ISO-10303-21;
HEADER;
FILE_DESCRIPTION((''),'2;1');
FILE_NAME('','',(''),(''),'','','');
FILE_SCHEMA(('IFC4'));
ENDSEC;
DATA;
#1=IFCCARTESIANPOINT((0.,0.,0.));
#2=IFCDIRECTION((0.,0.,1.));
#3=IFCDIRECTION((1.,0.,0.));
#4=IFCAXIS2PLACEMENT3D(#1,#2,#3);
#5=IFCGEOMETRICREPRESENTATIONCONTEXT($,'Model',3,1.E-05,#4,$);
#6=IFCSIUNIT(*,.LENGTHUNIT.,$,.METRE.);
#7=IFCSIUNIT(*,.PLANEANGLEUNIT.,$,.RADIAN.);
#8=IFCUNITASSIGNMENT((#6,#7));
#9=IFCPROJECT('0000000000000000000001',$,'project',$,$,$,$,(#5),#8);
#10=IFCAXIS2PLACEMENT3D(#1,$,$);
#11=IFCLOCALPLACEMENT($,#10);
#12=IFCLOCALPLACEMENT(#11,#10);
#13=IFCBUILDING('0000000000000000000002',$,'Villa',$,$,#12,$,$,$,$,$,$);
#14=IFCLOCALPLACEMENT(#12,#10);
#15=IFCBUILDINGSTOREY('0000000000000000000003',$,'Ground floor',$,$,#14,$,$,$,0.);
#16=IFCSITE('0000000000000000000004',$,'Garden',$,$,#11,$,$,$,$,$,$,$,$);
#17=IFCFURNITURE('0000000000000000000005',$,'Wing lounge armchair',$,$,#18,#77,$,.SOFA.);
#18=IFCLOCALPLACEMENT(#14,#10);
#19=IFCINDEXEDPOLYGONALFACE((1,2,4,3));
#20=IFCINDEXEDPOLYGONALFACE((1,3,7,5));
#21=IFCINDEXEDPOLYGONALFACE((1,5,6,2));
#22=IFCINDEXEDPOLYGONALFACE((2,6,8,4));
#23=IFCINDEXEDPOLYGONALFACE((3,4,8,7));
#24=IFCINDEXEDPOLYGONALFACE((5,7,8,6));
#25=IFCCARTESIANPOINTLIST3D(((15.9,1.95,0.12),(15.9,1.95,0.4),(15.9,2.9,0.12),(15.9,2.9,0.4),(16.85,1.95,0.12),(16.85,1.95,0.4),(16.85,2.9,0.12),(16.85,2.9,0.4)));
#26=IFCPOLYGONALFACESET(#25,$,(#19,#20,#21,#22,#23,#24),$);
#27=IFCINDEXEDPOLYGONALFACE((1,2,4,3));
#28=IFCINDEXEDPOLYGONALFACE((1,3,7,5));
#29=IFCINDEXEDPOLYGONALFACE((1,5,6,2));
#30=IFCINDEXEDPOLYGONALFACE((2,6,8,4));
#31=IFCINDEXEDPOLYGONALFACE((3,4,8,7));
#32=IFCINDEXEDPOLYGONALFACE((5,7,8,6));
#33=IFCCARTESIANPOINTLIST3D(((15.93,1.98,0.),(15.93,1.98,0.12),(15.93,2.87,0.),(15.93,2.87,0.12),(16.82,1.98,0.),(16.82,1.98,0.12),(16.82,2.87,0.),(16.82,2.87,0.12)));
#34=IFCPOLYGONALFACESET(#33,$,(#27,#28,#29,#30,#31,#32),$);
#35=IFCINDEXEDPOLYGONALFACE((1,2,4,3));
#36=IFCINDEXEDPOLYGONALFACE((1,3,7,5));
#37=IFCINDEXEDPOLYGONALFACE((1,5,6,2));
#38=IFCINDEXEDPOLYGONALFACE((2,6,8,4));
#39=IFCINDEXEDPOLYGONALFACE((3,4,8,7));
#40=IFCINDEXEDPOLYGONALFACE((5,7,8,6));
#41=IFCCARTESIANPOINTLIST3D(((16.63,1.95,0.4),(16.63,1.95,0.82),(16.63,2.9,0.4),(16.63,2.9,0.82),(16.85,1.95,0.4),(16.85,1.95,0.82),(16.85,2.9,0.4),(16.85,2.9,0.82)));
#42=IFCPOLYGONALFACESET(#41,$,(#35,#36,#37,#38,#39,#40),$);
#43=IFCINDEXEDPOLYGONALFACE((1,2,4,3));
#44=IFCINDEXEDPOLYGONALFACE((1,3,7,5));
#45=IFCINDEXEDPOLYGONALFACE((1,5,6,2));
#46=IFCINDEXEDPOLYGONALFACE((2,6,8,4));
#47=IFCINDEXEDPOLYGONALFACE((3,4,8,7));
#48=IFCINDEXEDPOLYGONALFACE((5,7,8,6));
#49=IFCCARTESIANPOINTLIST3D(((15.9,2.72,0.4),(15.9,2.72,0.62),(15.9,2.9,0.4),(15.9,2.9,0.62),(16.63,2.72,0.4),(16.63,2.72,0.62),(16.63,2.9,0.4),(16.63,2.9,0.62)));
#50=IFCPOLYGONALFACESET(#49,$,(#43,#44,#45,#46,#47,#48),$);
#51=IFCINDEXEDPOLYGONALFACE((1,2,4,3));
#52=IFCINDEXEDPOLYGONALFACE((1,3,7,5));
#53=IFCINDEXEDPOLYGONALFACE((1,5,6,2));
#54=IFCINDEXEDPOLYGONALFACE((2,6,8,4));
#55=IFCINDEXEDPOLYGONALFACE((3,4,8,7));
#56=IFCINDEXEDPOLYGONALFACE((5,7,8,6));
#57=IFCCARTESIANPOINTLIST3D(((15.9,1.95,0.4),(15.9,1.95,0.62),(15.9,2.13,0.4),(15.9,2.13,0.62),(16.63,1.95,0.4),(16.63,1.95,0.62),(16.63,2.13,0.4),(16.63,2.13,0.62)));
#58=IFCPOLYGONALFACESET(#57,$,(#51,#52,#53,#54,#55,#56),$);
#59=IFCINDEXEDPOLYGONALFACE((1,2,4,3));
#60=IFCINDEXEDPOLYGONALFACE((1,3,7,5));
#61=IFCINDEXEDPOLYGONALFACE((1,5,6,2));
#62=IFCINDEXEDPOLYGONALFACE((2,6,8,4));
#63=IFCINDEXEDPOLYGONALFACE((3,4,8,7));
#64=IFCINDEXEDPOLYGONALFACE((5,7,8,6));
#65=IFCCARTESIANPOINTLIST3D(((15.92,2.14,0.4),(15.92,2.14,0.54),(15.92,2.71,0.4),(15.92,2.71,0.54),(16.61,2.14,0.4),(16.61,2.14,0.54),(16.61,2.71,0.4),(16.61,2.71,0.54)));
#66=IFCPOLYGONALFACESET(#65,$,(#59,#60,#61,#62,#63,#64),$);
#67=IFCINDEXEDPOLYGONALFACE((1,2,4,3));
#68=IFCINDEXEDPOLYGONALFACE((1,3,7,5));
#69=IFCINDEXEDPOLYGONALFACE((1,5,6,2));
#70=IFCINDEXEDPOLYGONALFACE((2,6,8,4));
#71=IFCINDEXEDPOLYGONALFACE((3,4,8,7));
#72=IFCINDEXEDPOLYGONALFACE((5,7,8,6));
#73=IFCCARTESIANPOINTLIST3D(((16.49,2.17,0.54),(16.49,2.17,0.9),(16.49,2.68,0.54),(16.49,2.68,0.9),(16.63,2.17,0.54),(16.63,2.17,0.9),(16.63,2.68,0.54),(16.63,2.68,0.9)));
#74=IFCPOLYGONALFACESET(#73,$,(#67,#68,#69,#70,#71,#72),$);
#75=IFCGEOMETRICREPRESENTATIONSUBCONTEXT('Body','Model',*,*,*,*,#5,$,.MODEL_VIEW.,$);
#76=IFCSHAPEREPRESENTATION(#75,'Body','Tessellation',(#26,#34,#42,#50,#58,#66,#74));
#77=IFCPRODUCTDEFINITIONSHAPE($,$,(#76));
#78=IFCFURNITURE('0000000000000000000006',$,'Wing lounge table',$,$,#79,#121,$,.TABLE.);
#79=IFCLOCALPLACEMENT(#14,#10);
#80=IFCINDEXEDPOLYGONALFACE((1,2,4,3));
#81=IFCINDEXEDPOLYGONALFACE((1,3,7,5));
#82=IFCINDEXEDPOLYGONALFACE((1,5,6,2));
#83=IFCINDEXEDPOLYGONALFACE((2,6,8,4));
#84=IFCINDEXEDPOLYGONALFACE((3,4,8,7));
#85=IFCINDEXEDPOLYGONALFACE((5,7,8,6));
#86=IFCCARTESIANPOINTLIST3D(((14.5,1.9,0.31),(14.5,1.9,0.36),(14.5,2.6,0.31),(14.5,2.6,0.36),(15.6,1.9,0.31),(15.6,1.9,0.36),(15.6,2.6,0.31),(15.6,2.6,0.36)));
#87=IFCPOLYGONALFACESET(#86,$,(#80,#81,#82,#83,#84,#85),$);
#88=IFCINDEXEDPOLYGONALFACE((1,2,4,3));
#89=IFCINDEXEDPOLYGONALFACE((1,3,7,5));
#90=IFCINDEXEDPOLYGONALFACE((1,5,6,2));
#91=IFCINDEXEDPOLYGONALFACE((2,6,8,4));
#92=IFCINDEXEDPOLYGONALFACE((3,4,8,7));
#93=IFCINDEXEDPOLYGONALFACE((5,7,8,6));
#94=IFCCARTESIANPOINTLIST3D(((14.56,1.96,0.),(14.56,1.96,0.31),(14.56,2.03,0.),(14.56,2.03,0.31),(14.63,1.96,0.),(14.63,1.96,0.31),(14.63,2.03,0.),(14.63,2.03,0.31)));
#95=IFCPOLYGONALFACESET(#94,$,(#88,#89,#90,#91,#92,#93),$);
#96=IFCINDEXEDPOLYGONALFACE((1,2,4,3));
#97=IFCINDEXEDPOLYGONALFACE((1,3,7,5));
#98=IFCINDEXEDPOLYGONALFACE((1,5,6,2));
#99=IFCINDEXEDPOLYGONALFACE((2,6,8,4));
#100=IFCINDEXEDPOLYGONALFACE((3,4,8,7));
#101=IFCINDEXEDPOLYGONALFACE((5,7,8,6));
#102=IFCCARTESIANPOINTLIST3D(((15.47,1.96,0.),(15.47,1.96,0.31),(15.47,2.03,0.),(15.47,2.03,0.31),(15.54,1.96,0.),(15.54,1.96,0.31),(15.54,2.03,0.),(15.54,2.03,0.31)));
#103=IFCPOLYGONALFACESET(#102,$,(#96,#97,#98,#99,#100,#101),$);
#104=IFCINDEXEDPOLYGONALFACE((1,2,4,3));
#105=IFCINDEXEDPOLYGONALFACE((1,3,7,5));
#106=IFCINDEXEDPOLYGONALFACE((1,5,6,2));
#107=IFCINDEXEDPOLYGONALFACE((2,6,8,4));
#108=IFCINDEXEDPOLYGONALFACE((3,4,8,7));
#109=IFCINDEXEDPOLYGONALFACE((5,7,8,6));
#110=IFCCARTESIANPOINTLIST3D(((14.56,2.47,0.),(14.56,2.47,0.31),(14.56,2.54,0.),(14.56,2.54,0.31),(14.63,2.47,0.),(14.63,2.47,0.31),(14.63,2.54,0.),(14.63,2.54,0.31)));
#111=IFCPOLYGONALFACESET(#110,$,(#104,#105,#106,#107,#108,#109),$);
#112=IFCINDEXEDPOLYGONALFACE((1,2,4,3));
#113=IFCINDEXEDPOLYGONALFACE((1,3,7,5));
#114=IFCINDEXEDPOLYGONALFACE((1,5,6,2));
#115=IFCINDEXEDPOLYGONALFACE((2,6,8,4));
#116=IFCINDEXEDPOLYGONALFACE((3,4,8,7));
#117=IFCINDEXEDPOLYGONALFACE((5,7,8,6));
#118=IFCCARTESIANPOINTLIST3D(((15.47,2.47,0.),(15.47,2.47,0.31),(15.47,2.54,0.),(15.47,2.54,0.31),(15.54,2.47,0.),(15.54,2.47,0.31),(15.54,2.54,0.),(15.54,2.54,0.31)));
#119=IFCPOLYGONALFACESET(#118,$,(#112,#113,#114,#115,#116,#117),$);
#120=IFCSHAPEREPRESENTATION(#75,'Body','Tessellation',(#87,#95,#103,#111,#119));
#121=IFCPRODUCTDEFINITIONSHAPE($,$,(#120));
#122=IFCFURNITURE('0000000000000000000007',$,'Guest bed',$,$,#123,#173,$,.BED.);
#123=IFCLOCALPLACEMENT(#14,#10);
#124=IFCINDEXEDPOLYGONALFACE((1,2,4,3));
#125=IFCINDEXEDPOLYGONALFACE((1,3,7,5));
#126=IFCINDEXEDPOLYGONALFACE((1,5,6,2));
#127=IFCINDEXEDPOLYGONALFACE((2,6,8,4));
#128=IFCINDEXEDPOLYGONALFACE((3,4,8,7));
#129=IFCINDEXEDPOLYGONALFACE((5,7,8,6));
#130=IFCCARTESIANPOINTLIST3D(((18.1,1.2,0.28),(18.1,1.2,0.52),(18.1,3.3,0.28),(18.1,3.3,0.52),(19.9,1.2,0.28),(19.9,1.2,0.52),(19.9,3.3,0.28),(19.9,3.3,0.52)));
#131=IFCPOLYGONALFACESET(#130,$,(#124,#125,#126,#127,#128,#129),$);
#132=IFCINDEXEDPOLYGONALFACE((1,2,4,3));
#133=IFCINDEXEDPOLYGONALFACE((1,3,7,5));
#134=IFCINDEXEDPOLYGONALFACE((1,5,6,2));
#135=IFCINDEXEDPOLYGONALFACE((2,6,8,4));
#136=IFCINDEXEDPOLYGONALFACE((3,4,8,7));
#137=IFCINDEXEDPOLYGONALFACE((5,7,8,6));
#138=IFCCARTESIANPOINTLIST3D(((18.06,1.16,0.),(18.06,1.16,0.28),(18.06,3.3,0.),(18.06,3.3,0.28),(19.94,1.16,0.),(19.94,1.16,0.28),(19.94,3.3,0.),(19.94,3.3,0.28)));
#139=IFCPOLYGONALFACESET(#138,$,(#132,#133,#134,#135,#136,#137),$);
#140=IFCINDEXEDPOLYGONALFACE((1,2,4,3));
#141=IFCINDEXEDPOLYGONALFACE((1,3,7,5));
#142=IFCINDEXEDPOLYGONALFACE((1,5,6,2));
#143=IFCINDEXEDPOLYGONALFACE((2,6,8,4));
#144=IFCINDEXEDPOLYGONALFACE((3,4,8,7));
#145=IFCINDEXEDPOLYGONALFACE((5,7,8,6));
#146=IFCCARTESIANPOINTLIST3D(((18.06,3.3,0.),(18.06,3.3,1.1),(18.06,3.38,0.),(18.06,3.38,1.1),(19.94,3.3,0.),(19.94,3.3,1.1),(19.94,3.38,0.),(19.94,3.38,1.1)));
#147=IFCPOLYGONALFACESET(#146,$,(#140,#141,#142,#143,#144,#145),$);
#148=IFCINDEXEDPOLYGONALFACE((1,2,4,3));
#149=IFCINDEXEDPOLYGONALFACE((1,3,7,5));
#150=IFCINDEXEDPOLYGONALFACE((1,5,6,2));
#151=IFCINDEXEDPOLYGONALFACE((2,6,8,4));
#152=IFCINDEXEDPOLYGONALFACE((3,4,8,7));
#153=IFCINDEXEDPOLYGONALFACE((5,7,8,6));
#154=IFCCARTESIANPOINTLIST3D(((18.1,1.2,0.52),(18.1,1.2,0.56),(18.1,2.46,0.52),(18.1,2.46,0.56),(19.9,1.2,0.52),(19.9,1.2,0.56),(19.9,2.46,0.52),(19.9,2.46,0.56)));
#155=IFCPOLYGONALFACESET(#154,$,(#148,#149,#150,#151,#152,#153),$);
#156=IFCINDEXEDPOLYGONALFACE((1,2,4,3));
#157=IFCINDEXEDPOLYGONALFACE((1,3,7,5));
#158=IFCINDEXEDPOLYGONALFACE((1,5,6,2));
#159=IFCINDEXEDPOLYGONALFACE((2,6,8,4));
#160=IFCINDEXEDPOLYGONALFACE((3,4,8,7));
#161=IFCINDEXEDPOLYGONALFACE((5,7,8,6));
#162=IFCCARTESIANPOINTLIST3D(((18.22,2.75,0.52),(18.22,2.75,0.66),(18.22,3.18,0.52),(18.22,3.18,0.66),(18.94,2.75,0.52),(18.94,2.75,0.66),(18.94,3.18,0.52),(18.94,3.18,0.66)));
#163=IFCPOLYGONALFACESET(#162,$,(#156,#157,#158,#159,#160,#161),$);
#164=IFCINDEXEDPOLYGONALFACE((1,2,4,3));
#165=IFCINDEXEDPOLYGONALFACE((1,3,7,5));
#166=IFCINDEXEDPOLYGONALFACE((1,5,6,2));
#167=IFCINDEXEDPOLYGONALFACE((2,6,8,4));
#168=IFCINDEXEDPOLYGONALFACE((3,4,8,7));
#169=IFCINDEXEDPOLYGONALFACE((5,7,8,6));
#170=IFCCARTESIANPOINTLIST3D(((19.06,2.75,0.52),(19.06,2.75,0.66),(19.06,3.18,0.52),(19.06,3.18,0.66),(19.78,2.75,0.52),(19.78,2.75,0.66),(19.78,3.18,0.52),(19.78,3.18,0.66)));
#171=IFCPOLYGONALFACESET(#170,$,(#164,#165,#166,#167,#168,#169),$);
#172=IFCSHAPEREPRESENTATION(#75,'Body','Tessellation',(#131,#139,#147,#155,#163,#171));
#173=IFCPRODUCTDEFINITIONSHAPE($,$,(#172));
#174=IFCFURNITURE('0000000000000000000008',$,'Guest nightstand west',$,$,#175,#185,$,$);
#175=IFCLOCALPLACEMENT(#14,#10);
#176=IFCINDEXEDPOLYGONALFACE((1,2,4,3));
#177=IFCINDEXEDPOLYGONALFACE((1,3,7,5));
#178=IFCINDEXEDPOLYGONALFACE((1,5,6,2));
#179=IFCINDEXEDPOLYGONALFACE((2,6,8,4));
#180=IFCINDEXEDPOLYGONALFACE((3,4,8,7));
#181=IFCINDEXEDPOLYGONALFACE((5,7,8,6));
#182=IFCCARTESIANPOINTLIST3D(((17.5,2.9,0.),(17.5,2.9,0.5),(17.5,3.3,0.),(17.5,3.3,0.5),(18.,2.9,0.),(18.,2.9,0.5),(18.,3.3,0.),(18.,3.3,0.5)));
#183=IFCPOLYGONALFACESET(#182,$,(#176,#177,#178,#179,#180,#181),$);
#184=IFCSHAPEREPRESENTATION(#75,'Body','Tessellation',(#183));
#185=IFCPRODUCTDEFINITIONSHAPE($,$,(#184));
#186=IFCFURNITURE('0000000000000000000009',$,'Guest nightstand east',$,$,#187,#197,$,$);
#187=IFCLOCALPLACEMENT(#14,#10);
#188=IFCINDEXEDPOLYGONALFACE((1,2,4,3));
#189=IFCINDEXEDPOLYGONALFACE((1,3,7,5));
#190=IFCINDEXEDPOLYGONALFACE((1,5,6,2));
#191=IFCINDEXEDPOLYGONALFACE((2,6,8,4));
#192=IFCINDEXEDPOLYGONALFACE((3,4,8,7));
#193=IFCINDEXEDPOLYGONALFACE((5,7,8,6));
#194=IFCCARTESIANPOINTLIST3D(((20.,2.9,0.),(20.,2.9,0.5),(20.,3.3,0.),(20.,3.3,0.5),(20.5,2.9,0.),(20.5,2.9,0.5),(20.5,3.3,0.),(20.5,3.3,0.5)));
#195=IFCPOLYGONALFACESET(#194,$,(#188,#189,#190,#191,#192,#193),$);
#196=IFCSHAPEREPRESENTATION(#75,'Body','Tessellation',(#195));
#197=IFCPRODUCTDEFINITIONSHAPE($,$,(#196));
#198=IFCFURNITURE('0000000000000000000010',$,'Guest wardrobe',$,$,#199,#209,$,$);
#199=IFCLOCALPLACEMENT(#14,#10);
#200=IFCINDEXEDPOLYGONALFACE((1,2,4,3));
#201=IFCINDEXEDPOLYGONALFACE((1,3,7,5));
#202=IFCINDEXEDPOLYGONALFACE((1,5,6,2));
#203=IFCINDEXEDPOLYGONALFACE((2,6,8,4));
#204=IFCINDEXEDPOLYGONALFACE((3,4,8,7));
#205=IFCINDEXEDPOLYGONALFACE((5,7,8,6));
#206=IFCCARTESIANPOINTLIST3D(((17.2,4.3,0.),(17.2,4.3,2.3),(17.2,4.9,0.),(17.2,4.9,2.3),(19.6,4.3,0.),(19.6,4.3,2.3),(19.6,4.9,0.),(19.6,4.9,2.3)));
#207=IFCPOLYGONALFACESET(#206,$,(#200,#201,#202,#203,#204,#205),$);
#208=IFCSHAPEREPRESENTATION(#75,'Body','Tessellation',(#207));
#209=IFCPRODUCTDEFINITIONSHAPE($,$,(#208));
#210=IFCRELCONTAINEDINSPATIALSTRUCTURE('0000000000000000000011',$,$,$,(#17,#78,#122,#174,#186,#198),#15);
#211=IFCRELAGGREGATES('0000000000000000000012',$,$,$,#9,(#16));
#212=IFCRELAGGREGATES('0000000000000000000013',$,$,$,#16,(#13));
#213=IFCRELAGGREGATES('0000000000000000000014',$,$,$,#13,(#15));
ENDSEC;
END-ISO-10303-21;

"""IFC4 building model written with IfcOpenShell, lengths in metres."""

from ifc_helpers import new_model, si_unit, frame, frame_2d, origin, origin_with_axes, place, context, subcontext, project, spatial, rectangle, extrude, element, save


model = new_model("IFC4")

# Units and contexts
model_context = context("Model", 3, precision=1e-05, world=origin_with_axes())
body_context = subcontext(model_context, "Body", "Model", "MODEL_VIEW")
ifc_project = project(units=[si_unit("LENGTHUNIT", "METRE"), si_unit("PLANEANGLEUNIT", "RADIAN")], contexts=[model_context])

# Site, building, storey
site_placement = place(None, origin())
site = spatial("IfcSite", under=ifc_project, at=site_placement, Name="Garden")
building_placement = place(site_placement, origin())
building = spatial("IfcBuilding", under=site, at=building_placement, Name="Villa")
storey_placement = place(building_placement, origin())
storey = spatial("IfcBuildingStorey", under=building, at=storey_placement, Name="Ground floor", Elevation=0.0)

# Furniture
furniture_1_placement = place(storey_placement, frame((15.9, 2.9, 0.0), x_axis=(0.0, -1.0, 0.0)))
element("IfcFurniture", 1, at=furniture_1_placement, inside=storey, Name="Wing lounge armchair", PredefinedType="SOFA", context=body_context, shape_type="SweptSolid", body=[
    extrude(rectangle(XDim=0.95, YDim=0.95, at=frame_2d((0.475, 0.475))), frame((0.0, 0.0, 0.12)), (0.0, 0.0, 1.0), 0.28),
    extrude(rectangle(XDim=0.89, YDim=0.89, at=frame_2d((0.445, 0.445))), frame((0.03, 0.03, 0.0)), (0.0, 0.0, 1.0), 0.12),
    extrude(rectangle(XDim=0.95, YDim=0.22, at=frame_2d((0.475, 0.11))), frame((0.0, 0.73, 0.4)), (0.0, 0.0, 1.0), 0.42),
    extrude(rectangle(XDim=0.18, YDim=0.73, at=frame_2d((0.09, 0.365))), frame((0.0, 0.0, 0.4)), (0.0, 0.0, 1.0), 0.22),
    extrude(rectangle(XDim=0.18, YDim=0.73, at=frame_2d((0.09, 0.365))), frame((0.77, 0.0, 0.4)), (0.0, 0.0, 1.0), 0.22),
    extrude(rectangle(XDim=0.57, YDim=0.69, at=frame_2d((0.285, 0.345))), frame((0.19, 0.02, 0.4)), (0.0, 0.0, 1.0), 0.14),
    extrude(rectangle(XDim=0.51, YDim=0.14, at=frame_2d((0.255, 0.07))), frame((0.22, 0.59, 0.54)), (0.0, 0.0, 1.0), 0.36),
])
furniture_2_placement = place(storey_placement, frame((14.5, 1.9, 0.0)))
element("IfcFurniture", 2, at=furniture_2_placement, inside=storey, Name="Wing lounge table", PredefinedType="TABLE", context=body_context, shape_type="SweptSolid", body=[
    extrude(rectangle(XDim=1.1, YDim=0.7, at=frame_2d((0.55, 0.35))), frame((0.0, 0.0, 0.31)), (0.0, 0.0, 1.0), 0.05),
    extrude(rectangle(XDim=0.07, YDim=0.07, at=frame_2d((0.035, 0.035))), frame((0.06, 0.06, 0.0)), (0.0, 0.0, 1.0), 0.31),
    extrude(rectangle(XDim=0.07, YDim=0.07, at=frame_2d((0.035, 0.035))), frame((0.97, 0.06, 0.0)), (0.0, 0.0, 1.0), 0.31),
    extrude(rectangle(XDim=0.07, YDim=0.07, at=frame_2d((0.035, 0.035))), frame((0.06, 0.57, 0.0)), (0.0, 0.0, 1.0), 0.31),
    extrude(rectangle(XDim=0.07, YDim=0.07, at=frame_2d((0.035, 0.035))), frame((0.97, 0.57, 0.0)), (0.0, 0.0, 1.0), 0.31),
])
furniture_3_placement = place(storey_placement, frame((18.1, 1.2, 0.0)))
element("IfcFurniture", 3, at=furniture_3_placement, inside=storey, Name="Guest bed", PredefinedType="BED", context=body_context, shape_type="SweptSolid", body=[
    extrude(rectangle(XDim=1.8, YDim=2.1, at=frame_2d((0.9, 1.05))), frame((0.0, 0.0, 0.28)), (0.0, 0.0, 1.0), 0.24),
    extrude(rectangle(XDim=1.88, YDim=2.14, at=frame_2d((0.94, 1.07))), frame((-0.04, -0.04, 0.0)), (0.0, 0.0, 1.0), 0.28),
    extrude(rectangle(XDim=1.88, YDim=0.08, at=frame_2d((0.94, 0.04))), frame((-0.04, 2.1, 0.0)), (0.0, 0.0, 1.0), 1.1),
    extrude(rectangle(XDim=1.8, YDim=1.26, at=frame_2d((0.9, 0.63))), frame((0.0, 0.0, 0.52)), (0.0, 0.0, 1.0), 0.04),
    extrude(rectangle(XDim=0.72, YDim=0.43, at=frame_2d((0.36, 0.215))), frame((0.12, 1.55, 0.52)), (0.0, 0.0, 1.0), 0.14),
    extrude(rectangle(XDim=0.72, YDim=0.43, at=frame_2d((0.36, 0.215))), frame((0.96, 1.55, 0.52)), (0.0, 0.0, 1.0), 0.14),
])
for number, where, name in (
    (4, (17.5, 2.9, 0.0), "Guest nightstand west"),
    (5, (20.0, 2.9, 0.0), "Guest nightstand east"),
):
    element("IfcFurniture", number, at=place(storey_placement, frame(where)), inside=storey, Name=name, context=body_context, shape_type="SweptSolid", body=[
        extrude(rectangle(XDim=0.5, YDim=0.4, at=frame_2d((0.25, 0.2))), origin(), (0.0, 0.0, 1.0), 0.5),
    ])
furniture_4_placement = place(storey_placement, frame((17.2, 4.3, 0.0)))
element("IfcFurniture", 6, at=furniture_4_placement, inside=storey, Name="Guest wardrobe", context=body_context, shape_type="SweptSolid", body=[
    extrude(rectangle(XDim=2.4, YDim=0.6, at=frame_2d((1.2, 0.3))), origin(), (0.0, 0.0, 1.0), 2.3),
])

save(model, "model.ifc")
